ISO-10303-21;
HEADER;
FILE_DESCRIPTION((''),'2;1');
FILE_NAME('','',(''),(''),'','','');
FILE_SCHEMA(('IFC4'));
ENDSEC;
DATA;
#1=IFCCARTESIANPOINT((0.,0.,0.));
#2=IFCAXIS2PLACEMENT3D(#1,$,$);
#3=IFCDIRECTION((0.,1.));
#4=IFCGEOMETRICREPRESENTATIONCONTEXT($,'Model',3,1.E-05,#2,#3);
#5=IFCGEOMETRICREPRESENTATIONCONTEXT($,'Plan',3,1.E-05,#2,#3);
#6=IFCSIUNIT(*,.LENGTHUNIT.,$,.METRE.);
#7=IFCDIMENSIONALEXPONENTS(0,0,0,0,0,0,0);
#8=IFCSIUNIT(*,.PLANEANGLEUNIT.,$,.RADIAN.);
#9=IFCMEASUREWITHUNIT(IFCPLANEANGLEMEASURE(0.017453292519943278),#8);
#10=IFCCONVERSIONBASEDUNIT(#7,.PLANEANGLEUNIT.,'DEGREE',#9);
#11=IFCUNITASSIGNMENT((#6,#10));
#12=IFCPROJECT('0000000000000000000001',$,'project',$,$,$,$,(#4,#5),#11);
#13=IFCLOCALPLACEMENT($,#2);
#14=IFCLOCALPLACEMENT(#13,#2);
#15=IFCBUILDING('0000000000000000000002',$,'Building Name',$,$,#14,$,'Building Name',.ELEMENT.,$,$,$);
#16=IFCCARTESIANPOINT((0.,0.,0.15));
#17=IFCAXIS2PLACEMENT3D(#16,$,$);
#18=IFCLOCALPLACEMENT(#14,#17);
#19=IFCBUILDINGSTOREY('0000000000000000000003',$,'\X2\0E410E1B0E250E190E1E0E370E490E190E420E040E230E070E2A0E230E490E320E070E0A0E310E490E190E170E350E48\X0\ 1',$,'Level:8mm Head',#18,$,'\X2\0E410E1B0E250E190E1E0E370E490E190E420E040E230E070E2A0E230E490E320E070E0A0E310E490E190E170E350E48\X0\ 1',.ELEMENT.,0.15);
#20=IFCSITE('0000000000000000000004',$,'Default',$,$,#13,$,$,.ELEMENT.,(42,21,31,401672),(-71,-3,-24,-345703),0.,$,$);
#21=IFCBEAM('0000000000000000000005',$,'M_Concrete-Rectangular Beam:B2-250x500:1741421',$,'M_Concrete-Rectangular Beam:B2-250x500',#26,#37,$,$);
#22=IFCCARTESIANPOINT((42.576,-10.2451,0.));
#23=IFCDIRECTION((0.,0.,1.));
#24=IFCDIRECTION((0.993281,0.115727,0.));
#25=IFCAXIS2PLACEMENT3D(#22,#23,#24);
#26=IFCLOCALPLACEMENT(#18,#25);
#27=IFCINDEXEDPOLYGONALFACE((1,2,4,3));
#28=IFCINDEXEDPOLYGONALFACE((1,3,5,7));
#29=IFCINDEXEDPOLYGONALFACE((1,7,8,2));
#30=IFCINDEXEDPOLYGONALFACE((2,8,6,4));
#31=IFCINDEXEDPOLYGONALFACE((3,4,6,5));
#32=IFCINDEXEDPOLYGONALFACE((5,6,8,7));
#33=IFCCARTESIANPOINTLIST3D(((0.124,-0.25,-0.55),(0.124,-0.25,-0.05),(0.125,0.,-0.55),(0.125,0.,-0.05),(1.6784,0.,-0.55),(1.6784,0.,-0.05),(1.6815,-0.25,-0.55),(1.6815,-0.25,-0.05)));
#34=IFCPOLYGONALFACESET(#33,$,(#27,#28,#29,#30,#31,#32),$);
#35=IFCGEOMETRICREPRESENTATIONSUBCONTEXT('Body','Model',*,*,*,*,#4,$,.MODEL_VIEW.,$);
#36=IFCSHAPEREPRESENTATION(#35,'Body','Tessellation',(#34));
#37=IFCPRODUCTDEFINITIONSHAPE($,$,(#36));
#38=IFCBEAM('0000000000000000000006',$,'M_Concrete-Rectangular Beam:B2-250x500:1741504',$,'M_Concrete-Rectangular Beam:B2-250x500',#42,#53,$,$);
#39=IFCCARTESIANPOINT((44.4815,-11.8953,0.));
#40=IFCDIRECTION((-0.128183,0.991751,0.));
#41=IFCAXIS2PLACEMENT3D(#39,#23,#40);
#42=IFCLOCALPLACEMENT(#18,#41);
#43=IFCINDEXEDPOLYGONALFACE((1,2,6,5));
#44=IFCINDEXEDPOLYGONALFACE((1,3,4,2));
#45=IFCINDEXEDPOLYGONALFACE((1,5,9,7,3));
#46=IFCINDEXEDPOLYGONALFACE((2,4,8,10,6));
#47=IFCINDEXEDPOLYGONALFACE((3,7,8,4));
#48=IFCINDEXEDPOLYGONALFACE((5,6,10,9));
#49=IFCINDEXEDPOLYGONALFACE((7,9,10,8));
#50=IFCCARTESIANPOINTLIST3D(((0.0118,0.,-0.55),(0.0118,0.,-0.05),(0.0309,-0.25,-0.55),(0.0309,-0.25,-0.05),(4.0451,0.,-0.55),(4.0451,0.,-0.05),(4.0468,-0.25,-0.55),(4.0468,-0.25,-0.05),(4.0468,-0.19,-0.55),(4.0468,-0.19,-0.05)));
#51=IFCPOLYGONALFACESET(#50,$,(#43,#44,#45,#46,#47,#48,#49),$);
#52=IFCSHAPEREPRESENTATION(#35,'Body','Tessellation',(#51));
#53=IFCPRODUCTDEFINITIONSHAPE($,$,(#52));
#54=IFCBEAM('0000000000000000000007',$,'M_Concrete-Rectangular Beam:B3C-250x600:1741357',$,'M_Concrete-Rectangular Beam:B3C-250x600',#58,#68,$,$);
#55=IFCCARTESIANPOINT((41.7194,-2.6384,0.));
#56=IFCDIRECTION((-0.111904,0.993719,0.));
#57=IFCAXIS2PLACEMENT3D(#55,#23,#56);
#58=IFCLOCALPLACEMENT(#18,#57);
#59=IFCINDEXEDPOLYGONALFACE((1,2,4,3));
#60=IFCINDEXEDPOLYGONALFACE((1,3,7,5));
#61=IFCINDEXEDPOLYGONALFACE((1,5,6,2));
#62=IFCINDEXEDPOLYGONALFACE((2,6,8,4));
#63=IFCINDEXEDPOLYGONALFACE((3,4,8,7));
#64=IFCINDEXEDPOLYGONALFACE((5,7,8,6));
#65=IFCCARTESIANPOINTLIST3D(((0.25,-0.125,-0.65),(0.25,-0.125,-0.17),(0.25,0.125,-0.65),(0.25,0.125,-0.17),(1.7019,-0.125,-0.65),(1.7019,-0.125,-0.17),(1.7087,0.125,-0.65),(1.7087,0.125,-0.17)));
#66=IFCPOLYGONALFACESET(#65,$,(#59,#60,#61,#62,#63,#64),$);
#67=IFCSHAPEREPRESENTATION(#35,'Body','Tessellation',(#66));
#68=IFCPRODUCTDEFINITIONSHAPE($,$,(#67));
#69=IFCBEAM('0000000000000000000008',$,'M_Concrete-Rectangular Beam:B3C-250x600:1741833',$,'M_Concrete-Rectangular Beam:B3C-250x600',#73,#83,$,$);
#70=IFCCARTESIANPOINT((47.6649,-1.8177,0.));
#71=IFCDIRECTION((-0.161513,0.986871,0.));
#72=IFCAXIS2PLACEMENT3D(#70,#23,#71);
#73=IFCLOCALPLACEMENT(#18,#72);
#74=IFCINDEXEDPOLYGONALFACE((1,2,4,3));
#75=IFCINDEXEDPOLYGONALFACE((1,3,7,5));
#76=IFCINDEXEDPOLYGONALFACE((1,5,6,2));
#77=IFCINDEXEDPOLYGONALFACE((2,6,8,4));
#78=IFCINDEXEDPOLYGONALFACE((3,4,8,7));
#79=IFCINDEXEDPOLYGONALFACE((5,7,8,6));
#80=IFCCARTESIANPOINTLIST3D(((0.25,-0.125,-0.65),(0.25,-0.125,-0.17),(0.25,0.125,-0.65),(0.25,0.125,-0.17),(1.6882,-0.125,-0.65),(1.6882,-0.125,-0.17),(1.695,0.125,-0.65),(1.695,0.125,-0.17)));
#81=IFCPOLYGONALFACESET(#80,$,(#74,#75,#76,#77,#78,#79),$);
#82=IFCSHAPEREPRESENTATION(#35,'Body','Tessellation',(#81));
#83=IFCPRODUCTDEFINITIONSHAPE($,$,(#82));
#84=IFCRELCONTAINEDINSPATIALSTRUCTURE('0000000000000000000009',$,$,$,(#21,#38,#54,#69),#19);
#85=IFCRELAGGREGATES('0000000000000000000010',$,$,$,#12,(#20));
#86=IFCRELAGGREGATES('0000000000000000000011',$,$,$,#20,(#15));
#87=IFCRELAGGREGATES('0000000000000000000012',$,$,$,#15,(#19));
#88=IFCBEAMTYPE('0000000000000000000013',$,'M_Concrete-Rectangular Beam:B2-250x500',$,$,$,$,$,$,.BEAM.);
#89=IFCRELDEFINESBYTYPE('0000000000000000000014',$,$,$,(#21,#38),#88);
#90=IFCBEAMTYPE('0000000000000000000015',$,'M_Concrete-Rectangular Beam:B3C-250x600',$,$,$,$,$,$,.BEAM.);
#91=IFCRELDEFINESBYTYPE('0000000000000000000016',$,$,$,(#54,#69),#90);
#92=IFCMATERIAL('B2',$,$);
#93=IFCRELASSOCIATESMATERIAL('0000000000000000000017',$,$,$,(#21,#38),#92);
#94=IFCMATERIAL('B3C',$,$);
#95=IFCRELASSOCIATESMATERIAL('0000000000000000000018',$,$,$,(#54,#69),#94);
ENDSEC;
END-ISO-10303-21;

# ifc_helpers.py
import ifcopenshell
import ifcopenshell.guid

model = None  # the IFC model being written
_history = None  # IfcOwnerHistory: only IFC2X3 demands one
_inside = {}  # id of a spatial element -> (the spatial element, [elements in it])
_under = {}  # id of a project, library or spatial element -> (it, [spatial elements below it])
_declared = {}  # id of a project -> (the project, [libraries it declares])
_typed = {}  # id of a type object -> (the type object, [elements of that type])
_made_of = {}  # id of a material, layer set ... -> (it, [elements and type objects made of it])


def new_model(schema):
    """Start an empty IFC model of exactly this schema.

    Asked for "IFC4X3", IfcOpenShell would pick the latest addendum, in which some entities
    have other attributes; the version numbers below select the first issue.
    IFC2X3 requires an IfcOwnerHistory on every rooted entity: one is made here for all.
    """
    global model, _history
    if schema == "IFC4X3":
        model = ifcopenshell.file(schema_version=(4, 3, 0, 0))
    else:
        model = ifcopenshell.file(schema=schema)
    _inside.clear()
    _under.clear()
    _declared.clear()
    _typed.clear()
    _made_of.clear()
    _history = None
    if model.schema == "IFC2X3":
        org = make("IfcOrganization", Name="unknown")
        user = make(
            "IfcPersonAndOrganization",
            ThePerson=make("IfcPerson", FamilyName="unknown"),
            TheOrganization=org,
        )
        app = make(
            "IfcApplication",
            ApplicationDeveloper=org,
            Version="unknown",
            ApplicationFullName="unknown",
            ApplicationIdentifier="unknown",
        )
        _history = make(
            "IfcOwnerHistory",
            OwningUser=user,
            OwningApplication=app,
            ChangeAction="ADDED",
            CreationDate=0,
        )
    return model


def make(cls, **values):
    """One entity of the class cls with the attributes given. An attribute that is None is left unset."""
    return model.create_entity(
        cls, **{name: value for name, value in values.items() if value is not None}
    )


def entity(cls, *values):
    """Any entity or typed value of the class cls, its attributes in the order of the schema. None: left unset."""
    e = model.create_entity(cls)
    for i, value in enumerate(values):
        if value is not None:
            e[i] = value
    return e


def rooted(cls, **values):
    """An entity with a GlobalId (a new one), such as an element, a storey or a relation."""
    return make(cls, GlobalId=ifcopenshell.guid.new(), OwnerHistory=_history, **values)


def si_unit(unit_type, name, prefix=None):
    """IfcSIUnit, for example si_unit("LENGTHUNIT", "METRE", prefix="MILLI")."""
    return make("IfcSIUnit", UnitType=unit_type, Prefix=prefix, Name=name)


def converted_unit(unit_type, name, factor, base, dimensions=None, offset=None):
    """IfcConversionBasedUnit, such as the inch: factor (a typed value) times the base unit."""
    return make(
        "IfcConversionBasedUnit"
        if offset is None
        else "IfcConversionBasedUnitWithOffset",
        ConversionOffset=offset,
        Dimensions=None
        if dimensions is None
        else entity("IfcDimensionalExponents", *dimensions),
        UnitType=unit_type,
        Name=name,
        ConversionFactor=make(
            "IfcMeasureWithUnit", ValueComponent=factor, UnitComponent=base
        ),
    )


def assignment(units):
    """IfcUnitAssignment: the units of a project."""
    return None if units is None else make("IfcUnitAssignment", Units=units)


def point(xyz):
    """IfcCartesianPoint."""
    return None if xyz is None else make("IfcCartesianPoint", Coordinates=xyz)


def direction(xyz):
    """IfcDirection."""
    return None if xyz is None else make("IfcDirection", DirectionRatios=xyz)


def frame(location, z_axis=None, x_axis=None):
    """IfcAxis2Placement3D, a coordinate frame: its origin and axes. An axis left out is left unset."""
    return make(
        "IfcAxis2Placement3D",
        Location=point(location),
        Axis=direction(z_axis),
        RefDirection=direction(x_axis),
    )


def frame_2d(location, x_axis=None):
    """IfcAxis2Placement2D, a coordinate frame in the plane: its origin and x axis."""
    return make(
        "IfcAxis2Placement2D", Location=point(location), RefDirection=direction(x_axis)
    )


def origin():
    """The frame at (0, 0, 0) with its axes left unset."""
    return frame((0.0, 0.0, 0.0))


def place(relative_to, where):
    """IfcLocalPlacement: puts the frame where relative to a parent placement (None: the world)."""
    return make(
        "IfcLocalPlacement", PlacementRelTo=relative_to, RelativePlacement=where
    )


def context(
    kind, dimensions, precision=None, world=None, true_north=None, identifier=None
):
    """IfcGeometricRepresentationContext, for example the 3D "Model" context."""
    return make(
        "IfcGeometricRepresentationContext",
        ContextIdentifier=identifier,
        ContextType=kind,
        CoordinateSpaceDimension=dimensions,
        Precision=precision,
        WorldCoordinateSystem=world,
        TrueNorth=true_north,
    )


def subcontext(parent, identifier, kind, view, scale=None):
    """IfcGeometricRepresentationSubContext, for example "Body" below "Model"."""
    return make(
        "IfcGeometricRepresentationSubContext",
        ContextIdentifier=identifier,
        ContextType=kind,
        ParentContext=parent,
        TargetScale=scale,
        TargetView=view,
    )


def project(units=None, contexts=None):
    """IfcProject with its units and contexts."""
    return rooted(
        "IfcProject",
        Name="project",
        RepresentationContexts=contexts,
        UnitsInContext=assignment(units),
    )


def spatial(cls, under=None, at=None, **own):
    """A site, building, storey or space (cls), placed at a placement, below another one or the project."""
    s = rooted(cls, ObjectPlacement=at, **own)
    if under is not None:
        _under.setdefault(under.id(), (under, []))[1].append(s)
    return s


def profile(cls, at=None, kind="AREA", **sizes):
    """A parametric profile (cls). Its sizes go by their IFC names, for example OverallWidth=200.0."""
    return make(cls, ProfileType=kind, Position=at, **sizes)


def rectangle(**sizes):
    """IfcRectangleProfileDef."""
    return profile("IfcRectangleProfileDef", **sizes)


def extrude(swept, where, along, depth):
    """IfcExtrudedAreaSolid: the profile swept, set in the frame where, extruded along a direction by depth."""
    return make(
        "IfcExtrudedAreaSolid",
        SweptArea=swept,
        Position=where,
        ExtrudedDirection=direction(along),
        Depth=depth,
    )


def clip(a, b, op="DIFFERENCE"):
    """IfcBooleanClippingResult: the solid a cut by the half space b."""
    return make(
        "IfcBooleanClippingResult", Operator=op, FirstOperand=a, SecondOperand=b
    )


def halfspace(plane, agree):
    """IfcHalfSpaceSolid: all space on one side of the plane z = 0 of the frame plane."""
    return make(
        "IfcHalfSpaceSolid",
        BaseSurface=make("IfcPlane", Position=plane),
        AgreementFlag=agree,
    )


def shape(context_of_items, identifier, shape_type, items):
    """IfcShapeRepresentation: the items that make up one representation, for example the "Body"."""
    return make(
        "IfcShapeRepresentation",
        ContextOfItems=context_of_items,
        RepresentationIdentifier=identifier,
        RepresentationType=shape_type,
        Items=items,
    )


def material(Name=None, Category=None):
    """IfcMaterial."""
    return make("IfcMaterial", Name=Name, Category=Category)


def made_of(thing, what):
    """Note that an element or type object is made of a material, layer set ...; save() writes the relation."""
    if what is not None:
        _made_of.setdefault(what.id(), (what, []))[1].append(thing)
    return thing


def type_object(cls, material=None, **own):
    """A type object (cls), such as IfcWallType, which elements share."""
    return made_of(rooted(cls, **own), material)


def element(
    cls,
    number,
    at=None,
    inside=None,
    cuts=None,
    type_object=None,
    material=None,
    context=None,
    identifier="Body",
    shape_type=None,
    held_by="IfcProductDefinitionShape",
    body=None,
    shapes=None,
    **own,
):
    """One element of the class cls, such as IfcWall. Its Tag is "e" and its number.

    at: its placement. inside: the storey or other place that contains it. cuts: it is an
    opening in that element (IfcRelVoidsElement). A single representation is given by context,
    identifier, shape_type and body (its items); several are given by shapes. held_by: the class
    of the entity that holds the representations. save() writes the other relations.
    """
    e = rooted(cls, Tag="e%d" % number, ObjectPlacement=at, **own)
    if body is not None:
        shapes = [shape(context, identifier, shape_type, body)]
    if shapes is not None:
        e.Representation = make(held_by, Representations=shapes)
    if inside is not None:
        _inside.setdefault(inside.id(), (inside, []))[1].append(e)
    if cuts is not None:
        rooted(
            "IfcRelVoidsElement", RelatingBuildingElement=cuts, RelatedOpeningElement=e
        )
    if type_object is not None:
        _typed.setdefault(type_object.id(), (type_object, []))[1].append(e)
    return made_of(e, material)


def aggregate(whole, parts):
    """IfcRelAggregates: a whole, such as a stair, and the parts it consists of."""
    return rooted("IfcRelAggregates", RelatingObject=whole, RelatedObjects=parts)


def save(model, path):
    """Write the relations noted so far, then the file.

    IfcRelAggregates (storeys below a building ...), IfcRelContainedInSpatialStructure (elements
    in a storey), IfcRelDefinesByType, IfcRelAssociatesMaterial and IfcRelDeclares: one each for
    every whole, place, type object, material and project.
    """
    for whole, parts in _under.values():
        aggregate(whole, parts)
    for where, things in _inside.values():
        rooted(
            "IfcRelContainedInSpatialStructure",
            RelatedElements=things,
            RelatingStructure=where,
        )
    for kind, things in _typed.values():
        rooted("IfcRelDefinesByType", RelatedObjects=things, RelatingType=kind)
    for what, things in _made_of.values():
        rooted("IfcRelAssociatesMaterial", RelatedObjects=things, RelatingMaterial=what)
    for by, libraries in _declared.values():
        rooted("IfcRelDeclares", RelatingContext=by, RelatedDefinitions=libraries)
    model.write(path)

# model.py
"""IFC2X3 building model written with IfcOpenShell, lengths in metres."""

from ifc_helpers import new_model, entity, si_unit, converted_unit, direction, frame, frame_2d, origin, place, context, subcontext, project, spatial, rectangle, extrude, clip, halfspace, material, type_object, element, save


model = new_model("IFC2X3")

# Units and contexts
model_context = context("Model", 3, precision=1e-05, world=origin(), true_north=direction((0.0, 1.0)))
plan_context = context("Plan", 3, precision=1e-05, world=origin(), true_north=direction((0.0, 1.0)))
body_context = subcontext(model_context, "Body", "Model", "MODEL_VIEW")
ifc_project = project(units=[si_unit("LENGTHUNIT", "METRE"), converted_unit("PLANEANGLEUNIT", "DEGREE", entity("IfcPlaneAngleMeasure", 0.017453292519943278), si_unit("PLANEANGLEUNIT", "RADIAN"), dimensions=[0, 0, 0, 0, 0, 0, 0])], contexts=[model_context, plan_context])

# Site, building, storey
site_placement = place(None, origin())
site = spatial("IfcSite", under=ifc_project, at=site_placement, Name="Default", CompositionType="ELEMENT", RefLatitude=(42, 21, 31, 401672), RefLongitude=(-71, -3, -24, -345703), RefElevation=0.0)
building_placement = place(site_placement, origin())
building = spatial("IfcBuilding", under=site, at=building_placement, Name="Building Name", LongName="Building Name", CompositionType="ELEMENT")
storey_placement = place(building_placement, frame((0.0, 0.0, 0.15)))
storey = spatial("IfcBuildingStorey", under=building, at=storey_placement, Name="แปลนพื้นโครงสร้างชั้นที่ 1", ObjectType="Level:8mm Head", LongName="แปลนพื้นโครงสร้างชั้นที่ 1", CompositionType="ELEMENT", Elevation=0.15)

# Beams
ifc_material_1 = material(Name="B2")
beam_type_1 = type_object("IfcBeamType", Name="M_Concrete-Rectangular Beam:B2-250x500", PredefinedType="BEAM")
beam_1_placement = place(storey_placement, frame((42.576, -10.2451, 0.0), z_axis=(0.0, 0.0, 1.0), x_axis=(0.993281, 0.115727, 0.0)))
element("IfcBeam", 1, at=beam_1_placement, inside=storey, type_object=beam_type_1, material=ifc_material_1, Name="M_Concrete-Rectangular Beam:B2-250x500:1741421", ObjectType="M_Concrete-Rectangular Beam:B2-250x500", context=body_context, shape_type="Clipping", body=[
    clip(clip(extrude(rectangle(XDim=0.5, YDim=0.25, at=frame_2d((0.0, 0.0), x_axis=(1.0, 0.0))), frame((0.124, -0.125, -0.3), z_axis=(1.0, 0.0, 0.0), x_axis=(0.0, 0.0, -1.0)), (0.0, 0.0, 1.0), 1.5575), halfspace(frame((0.1323, 1.8916, -0.3), z_axis=(-0.999993, 0.003848, 0.0), x_axis=(0.0, 0.0, -1.0)), False)), halfspace(frame((1.6509, 2.1868, -0.55), z_axis=(0.999921, 0.01255, 0.0), x_axis=(0.01255, -0.999921, 0.0)), False)),
])
beam_2_placement = place(storey_placement, frame((44.4815, -11.8953, 0.0), z_axis=(0.0, 0.0, 1.0), x_axis=(-0.128183, 0.991751, 0.0)))
element("IfcBeam", 2, at=beam_2_placement, inside=storey, type_object=beam_type_1, material=ifc_material_1, Name="M_Concrete-Rectangular Beam:B2-250x500:1741504", ObjectType="M_Concrete-Rectangular Beam:B2-250x500", context=body_context, shape_type="Clipping", body=[
    clip(clip(extrude(rectangle(XDim=0.5, YDim=0.25, at=frame_2d((0.0, 0.0), x_axis=(1.0, 0.0))), frame((0.0118, -0.125, -0.3), z_axis=(1.0, 0.0, 0.0), x_axis=(0.0, 0.0, -1.0)), (0.0, 0.0, 1.0), 4.035), halfspace(frame((4.0837, -4.4403, -0.05), z_axis=(0.999962, 0.008688, 0.0), x_axis=(-0.008688, 0.999962, 0.0)), False)), halfspace(frame((-0.1049, 1.5231, -0.05), z_axis=(-0.997078, -0.076394, 0.0), x_axis=(0.076394, -0.997078, 0.0)), False)),
])
ifc_material_2 = material(Name="B3C")
beam_type_2 = type_object("IfcBeamType", Name="M_Concrete-Rectangular Beam:B3C-250x600", PredefinedType="BEAM")
beam_3_placement = place(storey_placement, frame((41.7194, -2.6384, 0.0), z_axis=(0.0, 0.0, 1.0), x_axis=(-0.111904, 0.993719, 0.0)))
element("IfcBeam", 3, at=beam_3_placement, inside=storey, type_object=beam_type_2, material=ifc_material_2, Name="M_Concrete-Rectangular Beam:B3C-250x600:1741357", ObjectType="M_Concrete-Rectangular Beam:B3C-250x600", context=body_context, shape_type="Clipping", body=[
    clip(extrude(rectangle(XDim=0.48, YDim=0.25, at=frame_2d((0.0, 0.0), x_axis=(1.0, 0.0))), frame((0.25, 0.0, -0.41), z_axis=(1.0, 0.0, 0.0), x_axis=(0.0, 0.0, -1.0)), (0.0, 0.0, 1.0), 1.4587), halfspace(frame((1.7093, 0.149, -0.05), z_axis=(0.999634, -0.02705, 0.0), x_axis=(-0.02705, -0.999634, 0.0)), False)),
])
beam_4_placement = place(storey_placement, frame((47.6649, -1.8177, 0.0), z_axis=(0.0, 0.0, 1.0), x_axis=(-0.161513, 0.986871, 0.0)))
element("IfcBeam", 4, at=beam_4_placement, inside=storey, type_object=beam_type_2, material=ifc_material_2, Name="M_Concrete-Rectangular Beam:B3C-250x600:1741833", ObjectType="M_Concrete-Rectangular Beam:B3C-250x600", context=body_context, shape_type="Clipping", body=[
    clip(extrude(rectangle(XDim=0.48, YDim=0.25, at=frame_2d((0.0, 0.0), x_axis=(1.0, 0.0))), frame((0.25, 0.0, -0.41), z_axis=(1.0, 0.0, 0.0), x_axis=(0.0, 0.0, -1.0)), (0.0, 0.0, 1.0), 1.445), halfspace(frame((1.6957, 0.149, -0.05), z_axis=(0.999626, -0.027347, 0.0), x_axis=(-0.027347, -0.999626, 0.0)), False)),
])

save(model, "model.ifc")
